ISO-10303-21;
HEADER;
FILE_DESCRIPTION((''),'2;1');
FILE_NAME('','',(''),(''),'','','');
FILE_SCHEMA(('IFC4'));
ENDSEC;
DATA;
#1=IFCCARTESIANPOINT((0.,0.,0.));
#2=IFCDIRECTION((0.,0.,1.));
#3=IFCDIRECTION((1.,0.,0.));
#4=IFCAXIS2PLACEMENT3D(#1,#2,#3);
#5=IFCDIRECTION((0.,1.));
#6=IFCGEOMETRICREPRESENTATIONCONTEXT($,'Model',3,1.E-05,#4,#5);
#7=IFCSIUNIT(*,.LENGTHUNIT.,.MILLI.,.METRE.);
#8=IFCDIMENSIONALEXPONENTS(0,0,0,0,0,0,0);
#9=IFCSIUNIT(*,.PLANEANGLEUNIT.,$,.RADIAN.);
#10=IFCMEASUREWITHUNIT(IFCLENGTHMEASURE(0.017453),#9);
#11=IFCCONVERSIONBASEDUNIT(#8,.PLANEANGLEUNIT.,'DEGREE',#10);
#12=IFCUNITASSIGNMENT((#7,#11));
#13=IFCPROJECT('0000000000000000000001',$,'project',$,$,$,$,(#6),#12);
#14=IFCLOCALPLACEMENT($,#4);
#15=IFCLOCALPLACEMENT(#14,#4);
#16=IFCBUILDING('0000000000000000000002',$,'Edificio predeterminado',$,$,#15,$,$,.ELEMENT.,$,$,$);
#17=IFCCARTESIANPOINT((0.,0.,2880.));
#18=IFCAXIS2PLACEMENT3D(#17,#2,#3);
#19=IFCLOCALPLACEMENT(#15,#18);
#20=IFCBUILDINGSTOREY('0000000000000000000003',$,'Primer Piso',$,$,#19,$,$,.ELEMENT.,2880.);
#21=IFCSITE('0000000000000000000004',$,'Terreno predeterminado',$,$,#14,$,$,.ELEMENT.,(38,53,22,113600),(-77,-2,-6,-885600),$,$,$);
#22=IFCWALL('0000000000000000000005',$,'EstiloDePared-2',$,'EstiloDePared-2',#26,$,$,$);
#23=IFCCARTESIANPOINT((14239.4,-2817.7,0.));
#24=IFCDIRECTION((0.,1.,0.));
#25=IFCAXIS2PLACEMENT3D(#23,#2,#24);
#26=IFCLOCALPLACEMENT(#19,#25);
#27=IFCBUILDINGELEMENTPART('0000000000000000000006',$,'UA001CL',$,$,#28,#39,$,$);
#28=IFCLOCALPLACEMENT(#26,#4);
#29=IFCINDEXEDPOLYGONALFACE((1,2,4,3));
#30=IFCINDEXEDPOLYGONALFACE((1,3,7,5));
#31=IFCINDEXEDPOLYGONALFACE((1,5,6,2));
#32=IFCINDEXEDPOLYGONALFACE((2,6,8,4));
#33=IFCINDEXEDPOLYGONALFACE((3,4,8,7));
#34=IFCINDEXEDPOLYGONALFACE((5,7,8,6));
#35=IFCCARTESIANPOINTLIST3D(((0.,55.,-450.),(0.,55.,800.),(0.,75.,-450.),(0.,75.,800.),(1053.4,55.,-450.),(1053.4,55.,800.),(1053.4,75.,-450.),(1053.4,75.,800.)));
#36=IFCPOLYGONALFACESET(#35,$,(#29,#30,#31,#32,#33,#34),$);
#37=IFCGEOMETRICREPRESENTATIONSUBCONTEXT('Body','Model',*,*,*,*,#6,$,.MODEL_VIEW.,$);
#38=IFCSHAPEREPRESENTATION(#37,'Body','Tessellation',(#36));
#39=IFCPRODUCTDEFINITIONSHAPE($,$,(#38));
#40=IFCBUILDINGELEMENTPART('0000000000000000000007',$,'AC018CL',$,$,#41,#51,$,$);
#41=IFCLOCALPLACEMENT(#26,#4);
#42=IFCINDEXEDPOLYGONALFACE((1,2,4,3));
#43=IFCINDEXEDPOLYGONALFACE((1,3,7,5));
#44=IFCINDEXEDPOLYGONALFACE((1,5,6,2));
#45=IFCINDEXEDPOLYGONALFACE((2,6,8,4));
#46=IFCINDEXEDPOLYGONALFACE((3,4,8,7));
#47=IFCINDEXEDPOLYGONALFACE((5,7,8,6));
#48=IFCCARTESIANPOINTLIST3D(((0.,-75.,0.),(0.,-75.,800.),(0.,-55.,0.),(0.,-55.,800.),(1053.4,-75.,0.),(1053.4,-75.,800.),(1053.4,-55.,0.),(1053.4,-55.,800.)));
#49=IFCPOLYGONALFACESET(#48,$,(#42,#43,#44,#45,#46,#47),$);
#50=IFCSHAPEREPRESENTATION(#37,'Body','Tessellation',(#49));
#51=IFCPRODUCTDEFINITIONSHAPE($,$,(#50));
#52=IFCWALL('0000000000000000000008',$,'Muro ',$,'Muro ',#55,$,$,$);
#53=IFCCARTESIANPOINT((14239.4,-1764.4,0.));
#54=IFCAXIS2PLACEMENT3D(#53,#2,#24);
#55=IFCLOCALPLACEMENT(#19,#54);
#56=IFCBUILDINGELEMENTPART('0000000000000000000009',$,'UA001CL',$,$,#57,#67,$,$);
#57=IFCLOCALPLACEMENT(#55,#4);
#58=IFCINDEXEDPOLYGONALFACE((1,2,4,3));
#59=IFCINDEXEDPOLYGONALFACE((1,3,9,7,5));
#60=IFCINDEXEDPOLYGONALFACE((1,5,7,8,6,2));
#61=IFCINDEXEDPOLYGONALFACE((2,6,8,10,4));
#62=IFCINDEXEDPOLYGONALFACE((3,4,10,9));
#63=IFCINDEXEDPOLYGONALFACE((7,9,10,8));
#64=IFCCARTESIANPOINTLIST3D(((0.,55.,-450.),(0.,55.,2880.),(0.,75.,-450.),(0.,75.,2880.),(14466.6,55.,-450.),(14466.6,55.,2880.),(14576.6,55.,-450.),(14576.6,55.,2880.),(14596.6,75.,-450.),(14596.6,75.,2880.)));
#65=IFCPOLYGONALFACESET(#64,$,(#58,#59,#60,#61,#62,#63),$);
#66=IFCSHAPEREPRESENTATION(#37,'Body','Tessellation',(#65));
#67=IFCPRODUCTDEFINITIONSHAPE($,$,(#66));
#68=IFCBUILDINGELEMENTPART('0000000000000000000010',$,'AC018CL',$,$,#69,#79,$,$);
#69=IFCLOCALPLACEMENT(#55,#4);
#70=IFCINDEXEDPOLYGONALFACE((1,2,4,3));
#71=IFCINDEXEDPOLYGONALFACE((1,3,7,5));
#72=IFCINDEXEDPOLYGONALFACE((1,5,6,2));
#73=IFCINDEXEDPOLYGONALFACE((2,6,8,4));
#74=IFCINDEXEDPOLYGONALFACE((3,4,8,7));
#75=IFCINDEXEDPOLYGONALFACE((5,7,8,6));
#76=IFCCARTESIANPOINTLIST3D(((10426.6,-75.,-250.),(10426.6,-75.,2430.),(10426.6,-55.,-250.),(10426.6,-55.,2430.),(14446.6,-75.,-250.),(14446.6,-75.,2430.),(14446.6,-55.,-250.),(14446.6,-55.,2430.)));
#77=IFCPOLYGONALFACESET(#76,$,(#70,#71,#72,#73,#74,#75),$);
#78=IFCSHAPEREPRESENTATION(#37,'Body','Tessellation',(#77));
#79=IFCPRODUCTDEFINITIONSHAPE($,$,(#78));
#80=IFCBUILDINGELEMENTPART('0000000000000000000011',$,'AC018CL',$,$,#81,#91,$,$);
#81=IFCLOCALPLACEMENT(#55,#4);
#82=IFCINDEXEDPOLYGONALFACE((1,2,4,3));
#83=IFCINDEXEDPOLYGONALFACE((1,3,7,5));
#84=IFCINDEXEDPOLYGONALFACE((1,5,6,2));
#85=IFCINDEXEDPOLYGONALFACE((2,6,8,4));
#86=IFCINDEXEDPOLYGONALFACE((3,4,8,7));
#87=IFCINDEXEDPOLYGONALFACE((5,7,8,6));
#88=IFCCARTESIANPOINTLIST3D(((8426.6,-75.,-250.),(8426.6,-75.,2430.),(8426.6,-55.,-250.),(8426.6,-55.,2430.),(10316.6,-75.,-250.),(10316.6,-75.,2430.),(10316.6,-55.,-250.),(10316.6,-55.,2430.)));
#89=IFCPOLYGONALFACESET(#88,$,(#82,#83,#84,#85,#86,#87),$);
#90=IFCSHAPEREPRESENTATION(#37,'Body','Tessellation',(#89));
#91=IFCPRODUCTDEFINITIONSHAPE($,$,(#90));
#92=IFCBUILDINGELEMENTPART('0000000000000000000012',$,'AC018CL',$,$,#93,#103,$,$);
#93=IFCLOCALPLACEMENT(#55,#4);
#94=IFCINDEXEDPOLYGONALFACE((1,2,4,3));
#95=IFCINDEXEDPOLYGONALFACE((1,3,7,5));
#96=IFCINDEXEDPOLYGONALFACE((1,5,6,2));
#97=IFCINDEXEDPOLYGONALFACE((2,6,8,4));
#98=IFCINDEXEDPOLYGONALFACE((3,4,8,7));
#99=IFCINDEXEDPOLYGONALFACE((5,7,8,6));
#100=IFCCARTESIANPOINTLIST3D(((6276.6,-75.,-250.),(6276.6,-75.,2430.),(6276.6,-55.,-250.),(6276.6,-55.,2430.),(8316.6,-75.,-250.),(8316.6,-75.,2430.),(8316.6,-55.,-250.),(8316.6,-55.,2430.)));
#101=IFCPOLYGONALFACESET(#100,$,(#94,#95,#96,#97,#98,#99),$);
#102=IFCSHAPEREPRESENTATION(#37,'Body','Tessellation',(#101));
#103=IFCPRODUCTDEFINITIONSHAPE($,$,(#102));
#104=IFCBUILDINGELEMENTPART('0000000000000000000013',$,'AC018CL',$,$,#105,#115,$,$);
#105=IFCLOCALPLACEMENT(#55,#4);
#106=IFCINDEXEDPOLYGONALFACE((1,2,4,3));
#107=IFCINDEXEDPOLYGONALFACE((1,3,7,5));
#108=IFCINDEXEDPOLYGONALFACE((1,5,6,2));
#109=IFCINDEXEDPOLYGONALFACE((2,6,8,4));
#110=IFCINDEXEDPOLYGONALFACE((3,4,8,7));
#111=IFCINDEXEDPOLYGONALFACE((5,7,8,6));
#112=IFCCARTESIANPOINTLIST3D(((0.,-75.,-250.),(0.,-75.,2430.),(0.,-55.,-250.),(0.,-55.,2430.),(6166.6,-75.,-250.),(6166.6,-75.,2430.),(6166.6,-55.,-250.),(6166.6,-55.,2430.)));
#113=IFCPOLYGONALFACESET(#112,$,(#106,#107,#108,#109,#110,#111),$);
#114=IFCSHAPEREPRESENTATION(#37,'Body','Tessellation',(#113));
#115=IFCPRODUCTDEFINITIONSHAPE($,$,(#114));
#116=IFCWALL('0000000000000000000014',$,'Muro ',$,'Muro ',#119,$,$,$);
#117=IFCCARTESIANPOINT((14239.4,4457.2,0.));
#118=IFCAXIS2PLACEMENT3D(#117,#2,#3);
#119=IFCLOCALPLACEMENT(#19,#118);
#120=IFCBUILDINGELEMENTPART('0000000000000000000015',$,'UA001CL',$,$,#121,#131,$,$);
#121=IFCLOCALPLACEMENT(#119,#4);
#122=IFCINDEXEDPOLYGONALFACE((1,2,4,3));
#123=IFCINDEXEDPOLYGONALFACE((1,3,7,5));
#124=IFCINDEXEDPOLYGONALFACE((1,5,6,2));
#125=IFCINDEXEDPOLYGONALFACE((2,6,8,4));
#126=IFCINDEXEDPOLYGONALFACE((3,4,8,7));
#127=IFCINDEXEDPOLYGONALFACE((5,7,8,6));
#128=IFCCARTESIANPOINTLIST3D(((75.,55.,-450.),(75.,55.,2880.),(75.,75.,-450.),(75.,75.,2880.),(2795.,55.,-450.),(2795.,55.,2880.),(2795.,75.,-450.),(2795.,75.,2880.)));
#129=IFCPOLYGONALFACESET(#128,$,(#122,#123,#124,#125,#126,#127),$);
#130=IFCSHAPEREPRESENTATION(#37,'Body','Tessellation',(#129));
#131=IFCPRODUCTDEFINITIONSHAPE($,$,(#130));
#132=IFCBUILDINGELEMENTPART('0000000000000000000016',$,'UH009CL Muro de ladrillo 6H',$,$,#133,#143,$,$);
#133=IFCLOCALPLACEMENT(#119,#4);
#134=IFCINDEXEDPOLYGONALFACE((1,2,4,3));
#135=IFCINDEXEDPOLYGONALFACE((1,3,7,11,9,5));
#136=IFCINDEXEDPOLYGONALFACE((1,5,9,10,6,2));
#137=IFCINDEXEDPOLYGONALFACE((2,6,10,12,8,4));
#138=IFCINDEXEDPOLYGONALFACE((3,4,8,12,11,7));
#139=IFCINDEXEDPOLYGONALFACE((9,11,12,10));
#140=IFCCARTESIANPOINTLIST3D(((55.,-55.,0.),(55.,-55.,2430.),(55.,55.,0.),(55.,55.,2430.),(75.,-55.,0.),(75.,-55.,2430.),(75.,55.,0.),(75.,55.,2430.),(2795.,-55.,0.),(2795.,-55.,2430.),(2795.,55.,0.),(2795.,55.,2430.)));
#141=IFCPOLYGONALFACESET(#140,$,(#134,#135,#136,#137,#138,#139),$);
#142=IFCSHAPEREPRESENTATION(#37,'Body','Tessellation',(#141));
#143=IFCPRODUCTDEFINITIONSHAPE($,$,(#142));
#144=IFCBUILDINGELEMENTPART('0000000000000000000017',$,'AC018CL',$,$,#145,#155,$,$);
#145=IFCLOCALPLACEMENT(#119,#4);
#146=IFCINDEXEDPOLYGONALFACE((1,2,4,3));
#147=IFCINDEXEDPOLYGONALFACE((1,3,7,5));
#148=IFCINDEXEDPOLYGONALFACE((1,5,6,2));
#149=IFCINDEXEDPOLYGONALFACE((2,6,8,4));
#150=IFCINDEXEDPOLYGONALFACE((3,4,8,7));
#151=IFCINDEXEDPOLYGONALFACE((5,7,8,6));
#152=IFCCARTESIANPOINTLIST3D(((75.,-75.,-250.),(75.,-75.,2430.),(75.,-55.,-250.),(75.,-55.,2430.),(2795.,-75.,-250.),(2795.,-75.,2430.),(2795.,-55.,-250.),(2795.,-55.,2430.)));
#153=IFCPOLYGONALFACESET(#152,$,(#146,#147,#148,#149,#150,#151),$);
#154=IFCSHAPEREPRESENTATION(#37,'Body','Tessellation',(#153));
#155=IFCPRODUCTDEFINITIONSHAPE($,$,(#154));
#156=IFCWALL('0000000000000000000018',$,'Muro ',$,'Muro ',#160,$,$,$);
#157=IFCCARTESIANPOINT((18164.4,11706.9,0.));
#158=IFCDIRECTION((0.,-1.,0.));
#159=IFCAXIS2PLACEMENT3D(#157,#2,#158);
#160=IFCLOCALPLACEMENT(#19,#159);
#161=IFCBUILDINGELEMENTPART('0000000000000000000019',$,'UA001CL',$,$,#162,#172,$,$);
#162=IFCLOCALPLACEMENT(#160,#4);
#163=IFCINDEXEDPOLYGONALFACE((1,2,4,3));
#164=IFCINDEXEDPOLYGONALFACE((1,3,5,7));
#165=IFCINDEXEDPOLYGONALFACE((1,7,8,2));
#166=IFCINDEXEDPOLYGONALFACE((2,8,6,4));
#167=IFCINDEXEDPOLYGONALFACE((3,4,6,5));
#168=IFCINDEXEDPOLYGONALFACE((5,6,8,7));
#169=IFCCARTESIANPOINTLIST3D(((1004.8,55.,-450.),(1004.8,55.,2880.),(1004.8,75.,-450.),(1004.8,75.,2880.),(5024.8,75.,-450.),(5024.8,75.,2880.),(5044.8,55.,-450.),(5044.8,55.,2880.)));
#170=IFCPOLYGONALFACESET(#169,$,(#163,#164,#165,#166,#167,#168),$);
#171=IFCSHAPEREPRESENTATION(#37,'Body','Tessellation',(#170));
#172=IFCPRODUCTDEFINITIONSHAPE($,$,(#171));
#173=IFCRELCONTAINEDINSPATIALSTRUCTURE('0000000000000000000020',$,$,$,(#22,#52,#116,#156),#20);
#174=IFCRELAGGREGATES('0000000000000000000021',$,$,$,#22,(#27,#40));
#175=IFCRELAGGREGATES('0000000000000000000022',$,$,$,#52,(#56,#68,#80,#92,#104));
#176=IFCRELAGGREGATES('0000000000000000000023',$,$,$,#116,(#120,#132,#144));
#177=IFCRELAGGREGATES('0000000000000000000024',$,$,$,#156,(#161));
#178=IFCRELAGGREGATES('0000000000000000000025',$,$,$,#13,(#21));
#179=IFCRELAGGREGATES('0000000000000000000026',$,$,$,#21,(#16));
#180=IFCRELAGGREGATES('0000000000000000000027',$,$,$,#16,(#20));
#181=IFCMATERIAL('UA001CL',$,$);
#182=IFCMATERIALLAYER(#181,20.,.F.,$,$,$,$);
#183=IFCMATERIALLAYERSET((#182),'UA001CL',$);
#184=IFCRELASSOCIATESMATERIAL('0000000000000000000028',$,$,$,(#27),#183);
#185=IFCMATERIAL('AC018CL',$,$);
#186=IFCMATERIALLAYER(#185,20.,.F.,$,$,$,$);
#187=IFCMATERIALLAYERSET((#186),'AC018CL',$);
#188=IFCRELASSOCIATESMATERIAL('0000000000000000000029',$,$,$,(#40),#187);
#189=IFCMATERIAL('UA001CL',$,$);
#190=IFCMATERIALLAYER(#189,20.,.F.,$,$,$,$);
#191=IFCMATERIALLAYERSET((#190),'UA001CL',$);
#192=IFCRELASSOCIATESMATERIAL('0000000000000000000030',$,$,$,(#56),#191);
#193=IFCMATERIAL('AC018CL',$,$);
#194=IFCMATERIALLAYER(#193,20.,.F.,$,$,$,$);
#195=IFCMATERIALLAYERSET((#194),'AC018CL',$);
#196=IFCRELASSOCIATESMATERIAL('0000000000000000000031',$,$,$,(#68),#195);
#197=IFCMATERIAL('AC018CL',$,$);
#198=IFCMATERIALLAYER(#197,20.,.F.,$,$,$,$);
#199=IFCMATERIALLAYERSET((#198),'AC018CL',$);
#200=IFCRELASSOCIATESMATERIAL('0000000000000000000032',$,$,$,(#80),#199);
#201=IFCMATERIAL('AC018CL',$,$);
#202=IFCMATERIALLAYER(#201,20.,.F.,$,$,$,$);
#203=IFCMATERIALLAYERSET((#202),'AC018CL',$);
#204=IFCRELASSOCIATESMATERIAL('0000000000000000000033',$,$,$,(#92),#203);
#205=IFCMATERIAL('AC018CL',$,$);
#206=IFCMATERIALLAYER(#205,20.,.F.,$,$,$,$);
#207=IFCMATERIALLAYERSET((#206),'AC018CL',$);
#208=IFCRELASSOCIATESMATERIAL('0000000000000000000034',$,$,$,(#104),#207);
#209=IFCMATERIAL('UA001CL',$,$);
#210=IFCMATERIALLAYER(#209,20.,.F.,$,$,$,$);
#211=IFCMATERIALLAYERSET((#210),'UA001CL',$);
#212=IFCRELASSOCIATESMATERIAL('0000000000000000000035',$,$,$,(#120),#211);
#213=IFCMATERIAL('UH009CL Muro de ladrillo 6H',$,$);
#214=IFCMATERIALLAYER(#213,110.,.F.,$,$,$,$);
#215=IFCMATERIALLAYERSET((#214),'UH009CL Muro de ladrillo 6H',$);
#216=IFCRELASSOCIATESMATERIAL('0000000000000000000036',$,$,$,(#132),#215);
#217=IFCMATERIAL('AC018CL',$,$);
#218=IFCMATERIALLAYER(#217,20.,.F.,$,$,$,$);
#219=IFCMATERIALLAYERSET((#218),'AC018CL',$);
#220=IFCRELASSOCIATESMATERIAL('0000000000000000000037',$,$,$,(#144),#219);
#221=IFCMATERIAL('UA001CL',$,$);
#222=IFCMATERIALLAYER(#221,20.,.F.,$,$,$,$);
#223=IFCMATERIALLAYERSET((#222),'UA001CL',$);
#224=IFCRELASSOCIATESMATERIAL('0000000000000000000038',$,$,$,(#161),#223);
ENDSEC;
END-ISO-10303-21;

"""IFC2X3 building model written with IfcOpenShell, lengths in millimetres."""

from ifc_helpers import new_model, entity, si_unit, converted_unit, direction, frame, origin_with_axes, place, context, subcontext, project, spatial, polyline, outline, extrude, material, layer, layer_set, layer_usage, element, aggregate, save


model = new_model("IFC2X3")

# Units and contexts
model_context = context("Model", 3, precision=1e-05, world=origin_with_axes(), true_north=direction((0.0, 1.0)))
body_context = subcontext(model_context, "Body", "Model", "MODEL_VIEW")
ifc_project = project(units=[si_unit("LENGTHUNIT", "METRE", prefix="MILLI"), converted_unit("PLANEANGLEUNIT", "DEGREE", entity("IfcLengthMeasure", 0.017453), si_unit("PLANEANGLEUNIT", "RADIAN"), dimensions=[0, 0, 0, 0, 0, 0, 0])], contexts=[model_context])

# Site, building, storey
site_placement = place(None, origin_with_axes())
site = spatial("IfcSite", under=ifc_project, at=site_placement, Name="Terreno predeterminado", CompositionType="ELEMENT", RefLatitude=(38, 53, 22, 113600), RefLongitude=(-77, -2, -6, -885600))
building_placement = place(site_placement, origin_with_axes())
building = spatial("IfcBuilding", under=site, at=building_placement, Name="Edificio predeterminado", CompositionType="ELEMENT")
storey_placement = place(building_placement, frame((0.0, 0.0, 2880.0), z_axis=(0.0, 0.0, 1.0), x_axis=(1.0, 0.0, 0.0)))
storey = spatial("IfcBuildingStorey", under=building, at=storey_placement, Name="Primer Piso", CompositionType="ELEMENT", Elevation=2880.0)

# Walls, building element parts
wall_1_placement = place(storey_placement, frame((14239.4, -2817.7, 0.0), z_axis=(0.0, 0.0, 1.0), x_axis=(0.0, 1.0, 0.0)))
wall_1 = element("IfcWall", 1, at=wall_1_placement, inside=storey, Name="EstiloDePared-2", ObjectType="EstiloDePared-2")
ifc_material_1 = material(Name="UA001CL")
ifc_layer_1 = layer(ifc_material_1, 20.0, ventilated=False)
ifc_layer_set_1 = layer_set([ifc_layer_1], Name="UA001CL")
ifc_layer_usage_1 = layer_usage(ifc_layer_set_1, "AXIS2", "NEGATIVE", -75.0)
building_element_part_1_placement = place(wall_1_placement, origin_with_axes())
building_element_part_1 = element("IfcBuildingElementPart", 2, at=building_element_part_1_placement, material=ifc_layer_usage_1, Name="UA001CL", context=body_context, shape_type="SweptSolid", body=[
    extrude(outline(polyline([(1053.4, 75.0), (1053.4, 55.0), (0.0, 55.0), (0.0, 75.0), (1053.4, 75.0)])), frame((0.0, 0.0, -450.0), z_axis=(0.0, 0.0, 1.0), x_axis=(1.0, 0.0, 0.0)), (0.0, 0.0, 1.0), 1250.0),
])
ifc_material_2 = material(Name="AC018CL")
ifc_layer_2 = layer(ifc_material_2, 20.0, ventilated=False)
ifc_layer_set_2 = layer_set([ifc_layer_2], Name="AC018CL")
ifc_layer_usage_2 = layer_usage(ifc_layer_set_2, "AXIS2", "NEGATIVE", 55.0)
building_element_part_2_placement = place(wall_1_placement, origin_with_axes())
building_element_part_2 = element("IfcBuildingElementPart", 3, at=building_element_part_2_placement, material=ifc_layer_usage_2, Name="AC018CL", context=body_context, shape_type="SweptSolid", body=[
    extrude(outline(polyline([(1053.4, -55.0), (1053.4, -75.0), (0.0, -75.0), (0.0, -55.0), (1053.4, -55.0)])), origin_with_axes(), (0.0, 0.0, 1.0), 800.0),
])
aggregate(wall_1, [building_element_part_1, building_element_part_2])
wall_2_placement = place(storey_placement, frame((14239.4, -1764.4, 0.0), z_axis=(0.0, 0.0, 1.0), x_axis=(0.0, 1.0, 0.0)))
wall_2 = element("IfcWall", 4, at=wall_2_placement, inside=storey, Name="Muro ", ObjectType="Muro ")
ifc_material_3 = material(Name="UA001CL")
ifc_layer_3 = layer(ifc_material_3, 20.0, ventilated=False)
ifc_layer_set_3 = layer_set([ifc_layer_3], Name="UA001CL")
ifc_layer_usage_3 = layer_usage(ifc_layer_set_3, "AXIS2", "NEGATIVE", -75.0)
building_element_part_3_placement = place(wall_2_placement, origin_with_axes())
building_element_part_3 = element("IfcBuildingElementPart", 5, at=building_element_part_3_placement, material=ifc_layer_usage_3, Name="UA001CL", context=body_context, shape_type="SweptSolid", body=[
    extrude(outline(polyline([(14596.6, 75.0), (14576.6, 55.0), (14466.6, 55.0), (0.0, 55.0), (0.0, 75.0), (14596.6, 75.0)])), frame((0.0, 0.0, -450.0), z_axis=(0.0, 0.0, 1.0), x_axis=(1.0, 0.0, 0.0)), (0.0, 0.0, 1.0), 3330.0),
])
ifc_material_4 = material(Name="AC018CL")
ifc_layer_4 = layer(ifc_material_4, 20.0, ventilated=False)
ifc_layer_set_4 = layer_set([ifc_layer_4], Name="AC018CL")
ifc_layer_usage_4 = layer_usage(ifc_layer_set_4, "AXIS2", "NEGATIVE", 55.0)
building_element_part_4_placement = place(wall_2_placement, origin_with_axes())
building_element_part_4 = element("IfcBuildingElementPart", 6, at=building_element_part_4_placement, material=ifc_layer_usage_4, Name="AC018CL", context=body_context, shape_type="SweptSolid", body=[
    extrude(outline(polyline([(14446.6, -55.0), (14446.6, -75.0), (10426.6, -75.0), (10426.6, -55.0), (14446.6, -55.0)])), frame((0.0, 0.0, -250.0), z_axis=(0.0, 0.0, 1.0), x_axis=(1.0, 0.0, 0.0)), (0.0, 0.0, 1.0), 2680.0),
])
ifc_material_5 = material(Name="AC018CL")
ifc_layer_5 = layer(ifc_material_5, 20.0, ventilated=False)
ifc_layer_set_5 = layer_set([ifc_layer_5], Name="AC018CL")
ifc_layer_usage_5 = layer_usage(ifc_layer_set_5, "AXIS2", "NEGATIVE", 55.0)
building_element_part_5_placement = place(wall_2_placement, origin_with_axes())
building_element_part_5 = element("IfcBuildingElementPart", 7, at=building_element_part_5_placement, material=ifc_layer_usage_5, Name="AC018CL", context=body_context, shape_type="SweptSolid", body=[
    extrude(outline(polyline([(10316.6, -55.0), (10316.6, -75.0), (8426.6, -75.0), (8426.6, -55.0), (10316.6, -55.0)])), frame((0.0, 0.0, -250.0), z_axis=(0.0, 0.0, 1.0), x_axis=(1.0, 0.0, 0.0)), (0.0, 0.0, 1.0), 2680.0),
])
ifc_material_6 = material(Name="AC018CL")
ifc_layer_6 = layer(ifc_material_6, 20.0, ventilated=False)
ifc_layer_set_6 = layer_set([ifc_layer_6], Name="AC018CL")
ifc_layer_usage_6 = layer_usage(ifc_layer_set_6, "AXIS2", "NEGATIVE", 55.0)
building_element_part_6_placement = place(wall_2_placement, origin_with_axes())
building_element_part_6 = element("IfcBuildingElementPart", 8, at=building_element_part_6_placement, material=ifc_layer_usage_6, Name="AC018CL", context=body_context, shape_type="SweptSolid", body=[
    extrude(outline(polyline([(8316.6, -55.0), (8316.6, -75.0), (6276.6, -75.0), (6276.6, -55.0), (8316.6, -55.0)])), frame((0.0, 0.0, -250.0), z_axis=(0.0, 0.0, 1.0), x_axis=(1.0, 0.0, 0.0)), (0.0, 0.0, 1.0), 2680.0),
])
ifc_material_7 = material(Name="AC018CL")
ifc_layer_7 = layer(ifc_material_7, 20.0, ventilated=False)
ifc_layer_set_7 = layer_set([ifc_layer_7], Name="AC018CL")
ifc_layer_usage_7 = layer_usage(ifc_layer_set_7, "AXIS2", "NEGATIVE", 55.0)
building_element_part_7_placement = place(wall_2_placement, origin_with_axes())
building_element_part_7 = element("IfcBuildingElementPart", 9, at=building_element_part_7_placement, material=ifc_layer_usage_7, Name="AC018CL", context=body_context, shape_type="SweptSolid", body=[
    extrude(outline(polyline([(6166.6, -55.0), (6166.6, -75.0), (0.0, -75.0), (0.0, -55.0), (6166.6, -55.0)])), frame((0.0, 0.0, -250.0), z_axis=(0.0, 0.0, 1.0), x_axis=(1.0, 0.0, 0.0)), (0.0, 0.0, 1.0), 2680.0),
])
aggregate(wall_2, [building_element_part_3, building_element_part_4, building_element_part_5, building_element_part_6, building_element_part_7])
wall_3_placement = place(storey_placement, frame((14239.4, 4457.2, 0.0), z_axis=(0.0, 0.0, 1.0), x_axis=(1.0, 0.0, 0.0)))
wall_3 = element("IfcWall", 10, at=wall_3_placement, inside=storey, Name="Muro ", ObjectType="Muro ")
ifc_material_8 = material(Name="UA001CL")
ifc_layer_8 = layer(ifc_material_8, 20.0, ventilated=False)
ifc_layer_set_8 = layer_set([ifc_layer_8], Name="UA001CL")
ifc_layer_usage_8 = layer_usage(ifc_layer_set_8, "AXIS2", "NEGATIVE", -75.0)
building_element_part_8_placement = place(wall_3_placement, origin_with_axes())
building_element_part_8 = element("IfcBuildingElementPart", 11, at=building_element_part_8_placement, material=ifc_layer_usage_8, Name="UA001CL", context=body_context, shape_type="SweptSolid", body=[
    extrude(outline(polyline([(2795.0, 75.0), (2795.0, 55.0), (75.0, 55.0), (75.0, 75.0), (2795.0, 75.0)])), frame((0.0, 0.0, -450.0), z_axis=(0.0, 0.0, 1.0), x_axis=(1.0, 0.0, 0.0)), (0.0, 0.0, 1.0), 3330.0),
])
ifc_material_9 = material(Name="UH009CL Muro de ladrillo 6H")
ifc_layer_9 = layer(ifc_material_9, 110.0, ventilated=False)
ifc_layer_set_9 = layer_set([ifc_layer_9], Name="UH009CL Muro de ladrillo 6H")
ifc_layer_usage_9 = layer_usage(ifc_layer_set_9, "AXIS2", "NEGATIVE", -55.0)
building_element_part_9_placement = place(wall_3_placement, origin_with_axes())
building_element_part_9 = element("IfcBuildingElementPart", 12, at=building_element_part_9_placement, material=ifc_layer_usage_9, Name="UH009CL Muro de ladrillo 6H", context=body_context, shape_type="SweptSolid", body=[
    extrude(outline(polyline([(2795.0, 55.0), (2795.0, -55.0), (75.0, -55.0), (55.0, -55.0), (55.0, 55.0), (75.0, 55.0), (2795.0, 55.0)])), origin_with_axes(), (0.0, 0.0, 1.0), 2430.0),
])
ifc_material_10 = material(Name="AC018CL")
ifc_layer_10 = layer(ifc_material_10, 20.0, ventilated=False)
ifc_layer_set_10 = layer_set([ifc_layer_10], Name="AC018CL")
ifc_layer_usage_10 = layer_usage(ifc_layer_set_10, "AXIS2", "NEGATIVE", 55.0)
building_element_part_10_placement = place(wall_3_placement, origin_with_axes())
building_element_part_10 = element("IfcBuildingElementPart", 13, at=building_element_part_10_placement, material=ifc_layer_usage_10, Name="AC018CL", context=body_context, shape_type="SweptSolid", body=[
    extrude(outline(polyline([(75.0, -55.0), (2795.0, -55.0), (2795.0, -75.0), (75.0, -75.0), (75.0, -55.0)])), frame((0.0, 0.0, -250.0), z_axis=(0.0, 0.0, 1.0), x_axis=(1.0, 0.0, 0.0)), (0.0, 0.0, 1.0), 2680.0),
])
aggregate(wall_3, [building_element_part_8, building_element_part_9, building_element_part_10])
wall_4_placement = place(storey_placement, frame((18164.4, 11706.9, 0.0), z_axis=(0.0, 0.0, 1.0), x_axis=(0.0, -1.0, 0.0)))
wall_4 = element("IfcWall", 14, at=wall_4_placement, inside=storey, Name="Muro ", ObjectType="Muro ")
ifc_material_11 = material(Name="UA001CL")
ifc_layer_11 = layer(ifc_material_11, 20.0, ventilated=False)
ifc_layer_set_11 = layer_set([ifc_layer_11], Name="UA001CL")
ifc_layer_usage_11 = layer_usage(ifc_layer_set_11, "AXIS2", "NEGATIVE", -75.0)
building_element_part_11_placement = place(wall_4_placement, origin_with_axes())
building_element_part_11 = element("IfcBuildingElementPart", 15, at=building_element_part_11_placement, material=ifc_layer_usage_11, Name="UA001CL", context=body_context, shape_type="SweptSolid", body=[
    extrude(outline(polyline([(5024.8, 75.0), (5044.8, 55.0), (1004.8, 55.0), (1004.8, 75.0), (5024.8, 75.0)])), frame((0.0, 0.0, -450.0), z_axis=(0.0, 0.0, 1.0), x_axis=(1.0, 0.0, 0.0)), (0.0, 0.0, 1.0), 3330.0),
])
aggregate(wall_4, [building_element_part_11])

save(model, "model.ifc")
